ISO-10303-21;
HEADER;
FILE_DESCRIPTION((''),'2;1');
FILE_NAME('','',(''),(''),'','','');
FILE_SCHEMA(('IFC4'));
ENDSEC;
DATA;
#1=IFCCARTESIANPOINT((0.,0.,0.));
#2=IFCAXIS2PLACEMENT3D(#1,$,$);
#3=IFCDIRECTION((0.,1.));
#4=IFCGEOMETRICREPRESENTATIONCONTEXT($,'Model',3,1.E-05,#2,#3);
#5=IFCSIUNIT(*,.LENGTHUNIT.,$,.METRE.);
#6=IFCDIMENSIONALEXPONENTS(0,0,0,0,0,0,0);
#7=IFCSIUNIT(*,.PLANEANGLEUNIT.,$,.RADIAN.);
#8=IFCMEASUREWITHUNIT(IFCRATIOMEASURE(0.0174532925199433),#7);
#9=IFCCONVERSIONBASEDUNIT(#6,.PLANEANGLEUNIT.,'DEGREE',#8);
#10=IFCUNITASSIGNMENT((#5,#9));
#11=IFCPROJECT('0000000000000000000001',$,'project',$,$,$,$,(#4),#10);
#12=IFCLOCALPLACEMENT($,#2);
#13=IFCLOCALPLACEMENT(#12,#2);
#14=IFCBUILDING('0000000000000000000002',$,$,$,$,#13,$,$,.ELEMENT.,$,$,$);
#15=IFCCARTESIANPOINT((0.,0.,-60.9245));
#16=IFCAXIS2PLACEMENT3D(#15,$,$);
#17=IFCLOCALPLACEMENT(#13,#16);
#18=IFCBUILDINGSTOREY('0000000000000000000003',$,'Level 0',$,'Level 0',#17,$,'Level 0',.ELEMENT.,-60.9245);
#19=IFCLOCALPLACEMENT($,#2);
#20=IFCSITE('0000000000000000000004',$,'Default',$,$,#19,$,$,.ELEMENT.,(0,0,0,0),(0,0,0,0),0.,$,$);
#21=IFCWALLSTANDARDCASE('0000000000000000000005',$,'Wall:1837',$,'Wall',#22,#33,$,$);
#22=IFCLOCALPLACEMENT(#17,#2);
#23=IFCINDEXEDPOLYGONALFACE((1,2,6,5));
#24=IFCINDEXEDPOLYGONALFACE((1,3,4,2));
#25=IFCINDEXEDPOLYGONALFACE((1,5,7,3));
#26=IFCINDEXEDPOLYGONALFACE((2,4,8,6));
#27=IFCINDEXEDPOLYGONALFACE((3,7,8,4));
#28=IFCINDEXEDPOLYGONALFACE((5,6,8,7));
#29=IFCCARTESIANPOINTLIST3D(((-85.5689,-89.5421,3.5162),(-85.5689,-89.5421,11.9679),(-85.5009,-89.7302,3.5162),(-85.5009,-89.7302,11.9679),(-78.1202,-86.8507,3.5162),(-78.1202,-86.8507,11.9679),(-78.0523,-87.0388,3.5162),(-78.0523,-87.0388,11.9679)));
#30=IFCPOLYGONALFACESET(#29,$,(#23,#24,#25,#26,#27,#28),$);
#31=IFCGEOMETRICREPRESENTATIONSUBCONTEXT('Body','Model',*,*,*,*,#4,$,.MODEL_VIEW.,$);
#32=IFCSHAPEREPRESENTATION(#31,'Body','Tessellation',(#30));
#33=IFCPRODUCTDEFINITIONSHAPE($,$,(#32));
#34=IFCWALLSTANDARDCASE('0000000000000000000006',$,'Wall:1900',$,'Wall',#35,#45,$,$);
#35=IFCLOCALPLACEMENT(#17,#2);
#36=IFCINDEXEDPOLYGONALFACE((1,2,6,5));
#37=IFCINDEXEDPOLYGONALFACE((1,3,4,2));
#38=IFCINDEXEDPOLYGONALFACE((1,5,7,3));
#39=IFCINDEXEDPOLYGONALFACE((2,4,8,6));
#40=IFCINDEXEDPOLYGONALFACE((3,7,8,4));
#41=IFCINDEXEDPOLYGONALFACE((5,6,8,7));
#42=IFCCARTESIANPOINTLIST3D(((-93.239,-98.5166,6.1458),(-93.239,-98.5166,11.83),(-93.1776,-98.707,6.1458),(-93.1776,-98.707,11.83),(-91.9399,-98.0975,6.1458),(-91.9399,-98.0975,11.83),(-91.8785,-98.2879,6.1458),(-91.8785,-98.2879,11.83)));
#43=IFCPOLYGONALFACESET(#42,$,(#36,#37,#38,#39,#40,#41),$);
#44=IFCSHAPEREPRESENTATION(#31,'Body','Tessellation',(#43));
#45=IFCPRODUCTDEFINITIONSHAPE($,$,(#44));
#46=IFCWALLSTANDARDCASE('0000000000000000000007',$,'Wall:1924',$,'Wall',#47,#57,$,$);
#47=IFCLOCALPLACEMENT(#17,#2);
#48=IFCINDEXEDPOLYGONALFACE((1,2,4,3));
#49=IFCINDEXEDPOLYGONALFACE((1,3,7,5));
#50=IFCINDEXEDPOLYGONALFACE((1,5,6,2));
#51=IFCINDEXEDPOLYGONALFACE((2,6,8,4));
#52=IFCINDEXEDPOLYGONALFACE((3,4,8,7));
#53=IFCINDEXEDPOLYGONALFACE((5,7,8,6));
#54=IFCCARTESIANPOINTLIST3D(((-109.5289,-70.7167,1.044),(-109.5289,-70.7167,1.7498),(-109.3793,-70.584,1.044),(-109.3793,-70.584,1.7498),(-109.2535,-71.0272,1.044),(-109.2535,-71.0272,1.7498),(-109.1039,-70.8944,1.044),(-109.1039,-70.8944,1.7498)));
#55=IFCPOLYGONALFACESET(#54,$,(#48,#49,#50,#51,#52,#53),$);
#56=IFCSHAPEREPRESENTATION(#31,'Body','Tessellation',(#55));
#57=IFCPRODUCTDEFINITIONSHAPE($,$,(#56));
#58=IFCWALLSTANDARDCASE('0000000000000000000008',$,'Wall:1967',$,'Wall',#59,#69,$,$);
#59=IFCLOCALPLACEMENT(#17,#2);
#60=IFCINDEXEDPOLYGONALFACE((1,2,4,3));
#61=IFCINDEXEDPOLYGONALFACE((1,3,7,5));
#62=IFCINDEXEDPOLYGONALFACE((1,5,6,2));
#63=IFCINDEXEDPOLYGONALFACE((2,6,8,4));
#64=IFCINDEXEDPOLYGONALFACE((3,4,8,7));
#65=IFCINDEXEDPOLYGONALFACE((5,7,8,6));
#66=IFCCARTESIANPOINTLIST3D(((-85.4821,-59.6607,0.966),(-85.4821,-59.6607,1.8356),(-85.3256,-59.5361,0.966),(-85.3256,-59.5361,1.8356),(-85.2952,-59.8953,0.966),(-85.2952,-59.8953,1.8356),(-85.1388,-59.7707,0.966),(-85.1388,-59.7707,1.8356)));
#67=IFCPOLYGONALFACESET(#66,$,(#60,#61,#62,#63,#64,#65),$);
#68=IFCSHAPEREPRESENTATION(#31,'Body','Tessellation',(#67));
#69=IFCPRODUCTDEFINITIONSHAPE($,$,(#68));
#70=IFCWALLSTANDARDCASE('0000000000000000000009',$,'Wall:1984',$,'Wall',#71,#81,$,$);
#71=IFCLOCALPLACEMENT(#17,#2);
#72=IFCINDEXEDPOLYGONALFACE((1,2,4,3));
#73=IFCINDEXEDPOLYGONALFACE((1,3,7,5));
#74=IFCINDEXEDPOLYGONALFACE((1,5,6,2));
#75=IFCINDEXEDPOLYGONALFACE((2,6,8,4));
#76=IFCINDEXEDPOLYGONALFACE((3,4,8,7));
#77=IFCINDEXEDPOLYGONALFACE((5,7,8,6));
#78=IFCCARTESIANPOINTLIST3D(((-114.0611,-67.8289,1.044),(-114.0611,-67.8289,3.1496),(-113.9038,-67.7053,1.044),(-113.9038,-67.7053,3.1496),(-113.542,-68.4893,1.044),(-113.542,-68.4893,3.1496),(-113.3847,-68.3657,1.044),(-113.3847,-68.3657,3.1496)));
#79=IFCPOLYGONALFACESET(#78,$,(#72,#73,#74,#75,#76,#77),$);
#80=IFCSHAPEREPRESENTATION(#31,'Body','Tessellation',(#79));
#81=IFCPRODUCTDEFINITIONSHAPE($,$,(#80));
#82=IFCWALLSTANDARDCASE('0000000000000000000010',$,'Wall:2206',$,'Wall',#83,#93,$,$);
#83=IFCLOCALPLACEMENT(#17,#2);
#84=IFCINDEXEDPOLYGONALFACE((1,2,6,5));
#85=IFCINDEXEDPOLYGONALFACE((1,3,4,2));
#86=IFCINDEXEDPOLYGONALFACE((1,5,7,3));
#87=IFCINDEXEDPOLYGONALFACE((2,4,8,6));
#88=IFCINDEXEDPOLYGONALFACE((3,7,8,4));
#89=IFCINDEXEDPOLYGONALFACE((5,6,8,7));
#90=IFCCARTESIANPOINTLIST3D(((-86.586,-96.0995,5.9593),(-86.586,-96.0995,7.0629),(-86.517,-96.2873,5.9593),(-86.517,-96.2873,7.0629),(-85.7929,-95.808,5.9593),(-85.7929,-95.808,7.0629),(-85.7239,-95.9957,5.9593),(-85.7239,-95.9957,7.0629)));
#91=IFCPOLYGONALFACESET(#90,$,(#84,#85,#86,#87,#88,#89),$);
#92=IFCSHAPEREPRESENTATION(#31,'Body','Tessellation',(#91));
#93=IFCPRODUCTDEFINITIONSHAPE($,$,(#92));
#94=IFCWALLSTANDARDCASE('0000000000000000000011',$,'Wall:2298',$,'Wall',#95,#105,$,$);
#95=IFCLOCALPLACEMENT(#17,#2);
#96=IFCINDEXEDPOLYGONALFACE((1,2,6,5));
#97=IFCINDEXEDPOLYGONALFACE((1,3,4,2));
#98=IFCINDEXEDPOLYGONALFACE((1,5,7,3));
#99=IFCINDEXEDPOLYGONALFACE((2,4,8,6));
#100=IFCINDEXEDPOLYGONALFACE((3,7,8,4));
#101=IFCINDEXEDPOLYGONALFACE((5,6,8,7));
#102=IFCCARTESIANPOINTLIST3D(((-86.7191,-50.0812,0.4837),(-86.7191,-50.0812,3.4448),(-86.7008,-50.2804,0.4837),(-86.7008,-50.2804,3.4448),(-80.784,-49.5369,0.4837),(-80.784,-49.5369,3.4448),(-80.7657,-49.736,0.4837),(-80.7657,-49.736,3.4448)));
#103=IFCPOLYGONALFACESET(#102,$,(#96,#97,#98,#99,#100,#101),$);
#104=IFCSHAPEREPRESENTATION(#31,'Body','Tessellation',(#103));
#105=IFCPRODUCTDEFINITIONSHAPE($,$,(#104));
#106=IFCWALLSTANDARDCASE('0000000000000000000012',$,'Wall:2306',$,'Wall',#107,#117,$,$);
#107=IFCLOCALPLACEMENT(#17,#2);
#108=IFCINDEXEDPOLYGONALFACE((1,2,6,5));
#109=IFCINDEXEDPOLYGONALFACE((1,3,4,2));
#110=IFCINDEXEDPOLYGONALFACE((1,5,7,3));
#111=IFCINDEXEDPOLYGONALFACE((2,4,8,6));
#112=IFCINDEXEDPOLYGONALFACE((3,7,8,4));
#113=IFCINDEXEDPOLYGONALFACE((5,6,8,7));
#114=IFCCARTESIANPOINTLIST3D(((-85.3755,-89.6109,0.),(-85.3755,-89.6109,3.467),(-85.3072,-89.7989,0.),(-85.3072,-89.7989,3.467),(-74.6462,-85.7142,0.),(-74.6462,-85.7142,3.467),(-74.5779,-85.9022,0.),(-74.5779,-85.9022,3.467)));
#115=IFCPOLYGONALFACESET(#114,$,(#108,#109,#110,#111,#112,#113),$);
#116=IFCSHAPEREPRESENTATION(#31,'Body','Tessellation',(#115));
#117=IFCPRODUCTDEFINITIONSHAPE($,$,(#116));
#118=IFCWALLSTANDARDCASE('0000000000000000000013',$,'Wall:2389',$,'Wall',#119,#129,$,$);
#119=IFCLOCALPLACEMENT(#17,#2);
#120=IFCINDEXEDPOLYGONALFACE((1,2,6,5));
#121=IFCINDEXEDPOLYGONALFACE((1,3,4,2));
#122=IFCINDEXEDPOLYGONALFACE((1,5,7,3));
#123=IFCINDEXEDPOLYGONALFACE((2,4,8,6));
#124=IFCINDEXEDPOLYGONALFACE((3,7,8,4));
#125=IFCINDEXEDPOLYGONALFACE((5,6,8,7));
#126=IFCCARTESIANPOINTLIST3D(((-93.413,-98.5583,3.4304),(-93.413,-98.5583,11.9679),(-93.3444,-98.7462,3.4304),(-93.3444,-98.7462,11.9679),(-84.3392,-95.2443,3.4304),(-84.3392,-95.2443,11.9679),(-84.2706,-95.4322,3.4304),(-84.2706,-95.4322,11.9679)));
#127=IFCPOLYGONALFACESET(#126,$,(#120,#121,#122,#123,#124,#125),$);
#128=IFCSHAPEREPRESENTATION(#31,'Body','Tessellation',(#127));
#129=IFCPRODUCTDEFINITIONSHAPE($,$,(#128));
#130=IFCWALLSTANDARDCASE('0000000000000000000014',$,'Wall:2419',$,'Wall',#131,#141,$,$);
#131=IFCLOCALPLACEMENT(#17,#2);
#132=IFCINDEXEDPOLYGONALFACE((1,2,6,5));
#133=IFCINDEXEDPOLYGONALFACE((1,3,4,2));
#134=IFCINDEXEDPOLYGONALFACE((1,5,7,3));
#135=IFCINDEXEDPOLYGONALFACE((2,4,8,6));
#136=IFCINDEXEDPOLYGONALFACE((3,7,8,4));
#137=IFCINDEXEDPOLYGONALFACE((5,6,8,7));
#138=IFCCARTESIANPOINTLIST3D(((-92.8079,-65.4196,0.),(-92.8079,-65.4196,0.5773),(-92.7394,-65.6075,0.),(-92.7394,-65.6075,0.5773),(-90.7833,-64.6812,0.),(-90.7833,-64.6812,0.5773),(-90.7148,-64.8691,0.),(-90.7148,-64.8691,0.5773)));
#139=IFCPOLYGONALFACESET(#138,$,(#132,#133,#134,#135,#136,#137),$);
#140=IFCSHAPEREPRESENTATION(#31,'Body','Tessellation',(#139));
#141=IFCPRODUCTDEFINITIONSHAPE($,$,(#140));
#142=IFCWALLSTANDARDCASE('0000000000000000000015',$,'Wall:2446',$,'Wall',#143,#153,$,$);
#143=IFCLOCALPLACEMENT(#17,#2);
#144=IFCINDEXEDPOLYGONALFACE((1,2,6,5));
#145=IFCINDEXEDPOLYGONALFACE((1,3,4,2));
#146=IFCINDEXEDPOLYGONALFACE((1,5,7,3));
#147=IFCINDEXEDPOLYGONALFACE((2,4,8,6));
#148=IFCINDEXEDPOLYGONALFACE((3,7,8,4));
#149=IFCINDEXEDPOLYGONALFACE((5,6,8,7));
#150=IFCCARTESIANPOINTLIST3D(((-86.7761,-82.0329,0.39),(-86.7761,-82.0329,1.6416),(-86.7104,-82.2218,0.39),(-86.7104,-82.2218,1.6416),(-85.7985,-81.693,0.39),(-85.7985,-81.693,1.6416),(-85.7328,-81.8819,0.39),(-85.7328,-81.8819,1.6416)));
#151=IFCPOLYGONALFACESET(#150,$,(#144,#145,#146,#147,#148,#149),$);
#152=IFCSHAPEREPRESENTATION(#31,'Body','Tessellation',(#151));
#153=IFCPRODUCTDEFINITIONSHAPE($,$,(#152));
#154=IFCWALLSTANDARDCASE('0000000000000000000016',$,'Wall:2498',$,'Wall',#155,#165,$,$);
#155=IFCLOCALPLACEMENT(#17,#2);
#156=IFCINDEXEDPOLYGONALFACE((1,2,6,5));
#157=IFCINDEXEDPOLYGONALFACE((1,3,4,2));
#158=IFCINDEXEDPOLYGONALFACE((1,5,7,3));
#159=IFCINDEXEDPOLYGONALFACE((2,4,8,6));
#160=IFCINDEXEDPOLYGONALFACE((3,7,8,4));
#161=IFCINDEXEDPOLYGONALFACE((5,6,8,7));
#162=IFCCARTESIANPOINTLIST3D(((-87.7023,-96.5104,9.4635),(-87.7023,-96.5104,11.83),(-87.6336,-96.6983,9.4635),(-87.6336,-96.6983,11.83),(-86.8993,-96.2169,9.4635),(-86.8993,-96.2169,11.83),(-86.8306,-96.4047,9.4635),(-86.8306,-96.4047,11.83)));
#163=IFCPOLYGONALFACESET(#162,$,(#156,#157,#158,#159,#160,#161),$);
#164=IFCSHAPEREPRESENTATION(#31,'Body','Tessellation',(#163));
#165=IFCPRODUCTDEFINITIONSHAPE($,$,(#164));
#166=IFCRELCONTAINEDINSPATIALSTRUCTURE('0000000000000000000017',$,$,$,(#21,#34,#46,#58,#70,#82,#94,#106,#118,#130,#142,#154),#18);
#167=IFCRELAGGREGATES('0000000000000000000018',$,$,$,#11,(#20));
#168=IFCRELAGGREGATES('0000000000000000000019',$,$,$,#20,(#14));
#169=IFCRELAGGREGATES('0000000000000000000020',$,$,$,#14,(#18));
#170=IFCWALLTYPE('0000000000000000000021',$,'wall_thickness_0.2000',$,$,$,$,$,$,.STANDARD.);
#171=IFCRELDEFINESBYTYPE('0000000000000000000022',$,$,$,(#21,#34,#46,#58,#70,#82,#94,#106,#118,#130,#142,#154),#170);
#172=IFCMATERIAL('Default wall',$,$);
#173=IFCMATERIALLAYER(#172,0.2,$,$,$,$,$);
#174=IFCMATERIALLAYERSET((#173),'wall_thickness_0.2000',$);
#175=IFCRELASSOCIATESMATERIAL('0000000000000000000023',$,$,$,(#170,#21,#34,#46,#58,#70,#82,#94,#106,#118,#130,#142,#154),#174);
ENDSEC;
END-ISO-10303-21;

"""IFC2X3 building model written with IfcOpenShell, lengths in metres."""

from ifc_helpers import new_model, entity, si_unit, converted_unit, direction, frame, origin, place, context, subcontext, project, spatial, polyline, outline, extrude, material, layer, layer_set, layer_usage, type_object, element, save


model = new_model("IFC2X3")

# Units and contexts
model_context = context("Model", 3, precision=1e-05, world=origin(), true_north=direction((0.0, 1.0)))
body_context = subcontext(model_context, "Body", "Model", "MODEL_VIEW")
ifc_project = project(units=[si_unit("LENGTHUNIT", "METRE"), converted_unit("PLANEANGLEUNIT", "DEGREE", entity("IfcRatioMeasure", 0.0174532925199433), si_unit("PLANEANGLEUNIT", "RADIAN"), dimensions=[0, 0, 0, 0, 0, 0, 0])], contexts=[model_context])

# Site, building, storey
site_placement = place(None, origin())
site = spatial("IfcSite", under=ifc_project, at=site_placement, Name="Default", CompositionType="ELEMENT", RefLatitude=(0, 0, 0, 0), RefLongitude=(0, 0, 0, 0), RefElevation=0.0)
placement_1 = place(None, origin())
building_placement = place(placement_1, origin())
building = spatial("IfcBuilding", under=site, at=building_placement, CompositionType="ELEMENT")
storey_placement = place(building_placement, frame((0.0, 0.0, -60.9245)))
storey = spatial("IfcBuildingStorey", under=building, at=storey_placement, Name="Level 0", ObjectType="Level 0", LongName="Level 0", CompositionType="ELEMENT", Elevation=-60.9245)

# Walls
ifc_material = material(Name="Default wall")
ifc_layer = layer(ifc_material, 0.2)
ifc_layer_set = layer_set([ifc_layer], Name="wall_thickness_0.2000")
ifc_layer_usage = layer_usage(ifc_layer_set, "AXIS2", "POSITIVE", -0.1)
wall_type = type_object("IfcWallType", Name="wall_thickness_0.2000", PredefinedType="STANDARD", material=ifc_layer_set)
placement_2 = place(building_placement, frame((0.0, 0.0, -57.4083)))
wall_1_placement = place(placement_2, frame((-85.5349, -89.6362, 0.0), z_axis=(0.0, 0.0, 1.0), x_axis=(0.940488, 0.339826, 0.0)))
element("IfcWallStandardCase", 1, at=wall_1_placement, inside=storey, type_object=wall_type, material=ifc_layer_usage, Name="Wall:1837", ObjectType="Wall", context=body_context, shape_type="SweptSolid", body=[
    extrude(outline(polyline([(7.92, -0.1), (7.92, 0.1), (0.0, 0.1), (0.0, -0.1), (7.92, -0.1)])), origin(), (0.0, 0.0, 1.0), 8.4517),
])
placement_3 = place(building_placement, frame((0.0, 0.0, -54.7787)))
wall_2_placement = place(placement_3, frame((-91.9092, -98.1927, 0.0), z_axis=(0.0, 0.0, 1.0), x_axis=(-0.951703, -0.307021, 0.0)))
element("IfcWallStandardCase", 2, at=wall_2_placement, inside=storey, type_object=wall_type, material=ifc_layer_usage, Name="Wall:1900", ObjectType="Wall", context=body_context, shape_type="SweptSolid", body=[
    extrude(outline(polyline([(1.365, -0.1), (1.365, 0.1), (0.0, 0.1), (0.0, -0.1), (1.365, -0.1)])), origin(), (0.0, 0.0, 1.0), 5.6842),
])
placement_4 = place(building_placement, frame((0.0, 0.0, -59.8805)))
wall_3_placement = place(placement_4, frame((-109.1787, -70.9608, 0.0), z_axis=(0.0, 0.0, 1.0), x_axis=(-0.663607, 0.748081, 0.0)))
element("IfcWallStandardCase", 3, at=wall_3_placement, inside=storey, type_object=wall_type, material=ifc_layer_usage, Name="Wall:1924", ObjectType="Wall", context=body_context, shape_type="SweptSolid", body=[
    extrude(outline(polyline([(0.415, -0.1), (0.415, 0.1), (0.0, 0.1), (0.0, -0.1), (0.415, -0.1)])), origin(), (0.0, 0.0, 1.0), 0.7057),
])
placement_5 = place(building_placement, frame((0.0, 0.0, -59.9585)))
wall_4_placement = place(placement_5, frame((-85.217, -59.833, 0.0), z_axis=(0.0, 0.0, 1.0), x_axis=(-0.623062, 0.782173, 0.0)))
element("IfcWallStandardCase", 4, at=wall_4_placement, inside=storey, type_object=wall_type, material=ifc_layer_usage, Name="Wall:1967", ObjectType="Wall", context=body_context, shape_type="SweptSolid", body=[
    extrude(outline(polyline([(0.2999, -0.1), (0.2999, 0.1), (0.0, 0.1), (0.0, -0.1), (0.2999, -0.1)])), origin(), (0.0, 0.0, 1.0), 0.8697),
])
placement_6 = place(building_placement, frame((0.0, 0.0, -59.8805)))
wall_5_placement = place(placement_6, frame((-113.9825, -67.7671, 0.0), z_axis=(0.0, 0.0, 1.0), x_axis=(0.617998, -0.78618, 0.0)))
element("IfcWallStandardCase", 5, at=wall_5_placement, inside=storey, type_object=wall_type, material=ifc_layer_usage, Name="Wall:1984", ObjectType="Wall", context=body_context, shape_type="SweptSolid", body=[
    extrude(outline(polyline([(0.84, -0.1), (0.84, 0.1), (0.0, 0.1), (0.0, -0.1), (0.84, -0.1)])), origin(), (0.0, 0.0, 1.0), 2.1056),
])
placement_7 = place(building_placement, frame((0.0, 0.0, -54.9652)))
wall_6_placement = place(placement_7, frame((-85.7584, -95.9018, 0.0), z_axis=(0.0, 0.0, 1.0), x_axis=(-0.938586, -0.345047, 0.0)))
element("IfcWallStandardCase", 6, at=wall_6_placement, inside=storey, type_object=wall_type, material=ifc_layer_usage, Name="Wall:2206", ObjectType="Wall", context=body_context, shape_type="SweptSolid", body=[
    extrude(outline(polyline([(0.845, -0.1), (0.845, 0.1), (0.0, 0.1), (0.0, -0.1), (0.845, -0.1)])), origin(), (0.0, 0.0, 1.0), 1.1036),
])
placement_8 = place(building_placement, frame((0.0, 0.0, -60.4408)))
wall_7_placement = place(placement_8, frame((-86.71, -50.1808, 0.0), z_axis=(0.0, 0.0, 1.0), x_axis=(0.995821, 0.091329, 0.0)))
element("IfcWallStandardCase", 7, at=wall_7_placement, inside=storey, type_object=wall_type, material=ifc_layer_usage, Name="Wall:2298", ObjectType="Wall", context=body_context, shape_type="SweptSolid", body=[
    extrude(outline(polyline([(5.96, -0.1), (5.96, 0.1), (0.0, 0.1), (0.0, -0.1), (5.96, -0.1)])), origin(), (0.0, 0.0, 1.0), 2.9611),
])
wall_8_placement = place(storey_placement, frame((-85.3414, -89.7049, 0.0), z_axis=(0.0, 0.0, 1.0), x_axis=(0.939931, 0.341366, 0.0)))
element("IfcWallStandardCase", 8, at=wall_8_placement, inside=storey, type_object=wall_type, material=ifc_layer_usage, Name="Wall:2306", ObjectType="Wall", context=body_context, shape_type="SweptSolid", body=[
    extrude(outline(polyline([(11.415, -0.1), (11.415, 0.1), (0.0, 0.1), (0.0, -0.1), (11.415, -0.1)])), origin(), (0.0, 0.0, 1.0), 3.467),
])
placement_9 = place(building_placement, frame((0.0, 0.0, -57.4941)))
wall_9_placement = place(placement_9, frame((-84.3049, -95.3382, 0.0), z_axis=(0.0, 0.0, 1.0), x_axis=(-0.939312, -0.343065, 0.0)))
element("IfcWallStandardCase", 9, at=wall_9_placement, inside=storey, type_object=wall_type, material=ifc_layer_usage, Name="Wall:2389", ObjectType="Wall", context=body_context, shape_type="SweptSolid", body=[
    extrude(outline(polyline([(9.66, -0.1), (9.66, 0.1), (0.0, 0.1), (0.0, -0.1), (9.66, -0.1)])), origin(), (0.0, 0.0, 1.0), 8.5375),
])
wall_10_placement = place(storey_placement, frame((-92.7736, -65.5135, 0.0), z_axis=(0.0, 0.0, 1.0), x_axis=(0.939472, 0.342625, 0.0)))
element("IfcWallStandardCase", 10, at=wall_10_placement, inside=storey, type_object=wall_type, material=ifc_layer_usage, Name="Wall:2419", ObjectType="Wall", context=body_context, shape_type="SweptSolid", body=[
    extrude(outline(polyline([(2.155, -0.1), (2.155, 0.1), (0.0, 0.1), (0.0, -0.1), (2.155, -0.1)])), origin(), (0.0, 0.0, 1.0), 0.5773),
])
placement_10 = place(building_placement, frame((0.0, 0.0, -60.5345)))
wall_11_placement = place(placement_10, frame((-86.7433, -82.1273, 0.0), z_axis=(0.0, 0.0, 1.0), x_axis=(0.944563, 0.328332, 0.0)))
element("IfcWallStandardCase", 11, at=wall_11_placement, inside=storey, type_object=wall_type, material=ifc_layer_usage, Name="Wall:2446", ObjectType="Wall", context=body_context, shape_type="SweptSolid", body=[
    extrude(outline(polyline([(1.035, -0.1), (1.035, 0.1), (0.0, 0.1), (0.0, -0.1), (1.035, -0.1)])), origin(), (0.0, 0.0, 1.0), 1.2516),
])
placement_11 = place(building_placement, frame((0.0, 0.0, -51.461)))
wall_12_placement = place(placement_11, frame((-87.668, -96.6044, 0.0), z_axis=(0.0, 0.0, 1.0), x_axis=(0.939217, 0.343325, 0.0)))
element("IfcWallStandardCase", 12, at=wall_12_placement, inside=storey, type_object=wall_type, material=ifc_layer_usage, Name="Wall:2498", ObjectType="Wall", context=body_context, shape_type="SweptSolid", body=[
    extrude(outline(polyline([(0.855, -0.1), (0.855, 0.1), (0.0, 0.1), (0.0, -0.1), (0.855, -0.1)])), origin(), (0.0, 0.0, 1.0), 2.3665),
])

save(model, "model.ifc")
